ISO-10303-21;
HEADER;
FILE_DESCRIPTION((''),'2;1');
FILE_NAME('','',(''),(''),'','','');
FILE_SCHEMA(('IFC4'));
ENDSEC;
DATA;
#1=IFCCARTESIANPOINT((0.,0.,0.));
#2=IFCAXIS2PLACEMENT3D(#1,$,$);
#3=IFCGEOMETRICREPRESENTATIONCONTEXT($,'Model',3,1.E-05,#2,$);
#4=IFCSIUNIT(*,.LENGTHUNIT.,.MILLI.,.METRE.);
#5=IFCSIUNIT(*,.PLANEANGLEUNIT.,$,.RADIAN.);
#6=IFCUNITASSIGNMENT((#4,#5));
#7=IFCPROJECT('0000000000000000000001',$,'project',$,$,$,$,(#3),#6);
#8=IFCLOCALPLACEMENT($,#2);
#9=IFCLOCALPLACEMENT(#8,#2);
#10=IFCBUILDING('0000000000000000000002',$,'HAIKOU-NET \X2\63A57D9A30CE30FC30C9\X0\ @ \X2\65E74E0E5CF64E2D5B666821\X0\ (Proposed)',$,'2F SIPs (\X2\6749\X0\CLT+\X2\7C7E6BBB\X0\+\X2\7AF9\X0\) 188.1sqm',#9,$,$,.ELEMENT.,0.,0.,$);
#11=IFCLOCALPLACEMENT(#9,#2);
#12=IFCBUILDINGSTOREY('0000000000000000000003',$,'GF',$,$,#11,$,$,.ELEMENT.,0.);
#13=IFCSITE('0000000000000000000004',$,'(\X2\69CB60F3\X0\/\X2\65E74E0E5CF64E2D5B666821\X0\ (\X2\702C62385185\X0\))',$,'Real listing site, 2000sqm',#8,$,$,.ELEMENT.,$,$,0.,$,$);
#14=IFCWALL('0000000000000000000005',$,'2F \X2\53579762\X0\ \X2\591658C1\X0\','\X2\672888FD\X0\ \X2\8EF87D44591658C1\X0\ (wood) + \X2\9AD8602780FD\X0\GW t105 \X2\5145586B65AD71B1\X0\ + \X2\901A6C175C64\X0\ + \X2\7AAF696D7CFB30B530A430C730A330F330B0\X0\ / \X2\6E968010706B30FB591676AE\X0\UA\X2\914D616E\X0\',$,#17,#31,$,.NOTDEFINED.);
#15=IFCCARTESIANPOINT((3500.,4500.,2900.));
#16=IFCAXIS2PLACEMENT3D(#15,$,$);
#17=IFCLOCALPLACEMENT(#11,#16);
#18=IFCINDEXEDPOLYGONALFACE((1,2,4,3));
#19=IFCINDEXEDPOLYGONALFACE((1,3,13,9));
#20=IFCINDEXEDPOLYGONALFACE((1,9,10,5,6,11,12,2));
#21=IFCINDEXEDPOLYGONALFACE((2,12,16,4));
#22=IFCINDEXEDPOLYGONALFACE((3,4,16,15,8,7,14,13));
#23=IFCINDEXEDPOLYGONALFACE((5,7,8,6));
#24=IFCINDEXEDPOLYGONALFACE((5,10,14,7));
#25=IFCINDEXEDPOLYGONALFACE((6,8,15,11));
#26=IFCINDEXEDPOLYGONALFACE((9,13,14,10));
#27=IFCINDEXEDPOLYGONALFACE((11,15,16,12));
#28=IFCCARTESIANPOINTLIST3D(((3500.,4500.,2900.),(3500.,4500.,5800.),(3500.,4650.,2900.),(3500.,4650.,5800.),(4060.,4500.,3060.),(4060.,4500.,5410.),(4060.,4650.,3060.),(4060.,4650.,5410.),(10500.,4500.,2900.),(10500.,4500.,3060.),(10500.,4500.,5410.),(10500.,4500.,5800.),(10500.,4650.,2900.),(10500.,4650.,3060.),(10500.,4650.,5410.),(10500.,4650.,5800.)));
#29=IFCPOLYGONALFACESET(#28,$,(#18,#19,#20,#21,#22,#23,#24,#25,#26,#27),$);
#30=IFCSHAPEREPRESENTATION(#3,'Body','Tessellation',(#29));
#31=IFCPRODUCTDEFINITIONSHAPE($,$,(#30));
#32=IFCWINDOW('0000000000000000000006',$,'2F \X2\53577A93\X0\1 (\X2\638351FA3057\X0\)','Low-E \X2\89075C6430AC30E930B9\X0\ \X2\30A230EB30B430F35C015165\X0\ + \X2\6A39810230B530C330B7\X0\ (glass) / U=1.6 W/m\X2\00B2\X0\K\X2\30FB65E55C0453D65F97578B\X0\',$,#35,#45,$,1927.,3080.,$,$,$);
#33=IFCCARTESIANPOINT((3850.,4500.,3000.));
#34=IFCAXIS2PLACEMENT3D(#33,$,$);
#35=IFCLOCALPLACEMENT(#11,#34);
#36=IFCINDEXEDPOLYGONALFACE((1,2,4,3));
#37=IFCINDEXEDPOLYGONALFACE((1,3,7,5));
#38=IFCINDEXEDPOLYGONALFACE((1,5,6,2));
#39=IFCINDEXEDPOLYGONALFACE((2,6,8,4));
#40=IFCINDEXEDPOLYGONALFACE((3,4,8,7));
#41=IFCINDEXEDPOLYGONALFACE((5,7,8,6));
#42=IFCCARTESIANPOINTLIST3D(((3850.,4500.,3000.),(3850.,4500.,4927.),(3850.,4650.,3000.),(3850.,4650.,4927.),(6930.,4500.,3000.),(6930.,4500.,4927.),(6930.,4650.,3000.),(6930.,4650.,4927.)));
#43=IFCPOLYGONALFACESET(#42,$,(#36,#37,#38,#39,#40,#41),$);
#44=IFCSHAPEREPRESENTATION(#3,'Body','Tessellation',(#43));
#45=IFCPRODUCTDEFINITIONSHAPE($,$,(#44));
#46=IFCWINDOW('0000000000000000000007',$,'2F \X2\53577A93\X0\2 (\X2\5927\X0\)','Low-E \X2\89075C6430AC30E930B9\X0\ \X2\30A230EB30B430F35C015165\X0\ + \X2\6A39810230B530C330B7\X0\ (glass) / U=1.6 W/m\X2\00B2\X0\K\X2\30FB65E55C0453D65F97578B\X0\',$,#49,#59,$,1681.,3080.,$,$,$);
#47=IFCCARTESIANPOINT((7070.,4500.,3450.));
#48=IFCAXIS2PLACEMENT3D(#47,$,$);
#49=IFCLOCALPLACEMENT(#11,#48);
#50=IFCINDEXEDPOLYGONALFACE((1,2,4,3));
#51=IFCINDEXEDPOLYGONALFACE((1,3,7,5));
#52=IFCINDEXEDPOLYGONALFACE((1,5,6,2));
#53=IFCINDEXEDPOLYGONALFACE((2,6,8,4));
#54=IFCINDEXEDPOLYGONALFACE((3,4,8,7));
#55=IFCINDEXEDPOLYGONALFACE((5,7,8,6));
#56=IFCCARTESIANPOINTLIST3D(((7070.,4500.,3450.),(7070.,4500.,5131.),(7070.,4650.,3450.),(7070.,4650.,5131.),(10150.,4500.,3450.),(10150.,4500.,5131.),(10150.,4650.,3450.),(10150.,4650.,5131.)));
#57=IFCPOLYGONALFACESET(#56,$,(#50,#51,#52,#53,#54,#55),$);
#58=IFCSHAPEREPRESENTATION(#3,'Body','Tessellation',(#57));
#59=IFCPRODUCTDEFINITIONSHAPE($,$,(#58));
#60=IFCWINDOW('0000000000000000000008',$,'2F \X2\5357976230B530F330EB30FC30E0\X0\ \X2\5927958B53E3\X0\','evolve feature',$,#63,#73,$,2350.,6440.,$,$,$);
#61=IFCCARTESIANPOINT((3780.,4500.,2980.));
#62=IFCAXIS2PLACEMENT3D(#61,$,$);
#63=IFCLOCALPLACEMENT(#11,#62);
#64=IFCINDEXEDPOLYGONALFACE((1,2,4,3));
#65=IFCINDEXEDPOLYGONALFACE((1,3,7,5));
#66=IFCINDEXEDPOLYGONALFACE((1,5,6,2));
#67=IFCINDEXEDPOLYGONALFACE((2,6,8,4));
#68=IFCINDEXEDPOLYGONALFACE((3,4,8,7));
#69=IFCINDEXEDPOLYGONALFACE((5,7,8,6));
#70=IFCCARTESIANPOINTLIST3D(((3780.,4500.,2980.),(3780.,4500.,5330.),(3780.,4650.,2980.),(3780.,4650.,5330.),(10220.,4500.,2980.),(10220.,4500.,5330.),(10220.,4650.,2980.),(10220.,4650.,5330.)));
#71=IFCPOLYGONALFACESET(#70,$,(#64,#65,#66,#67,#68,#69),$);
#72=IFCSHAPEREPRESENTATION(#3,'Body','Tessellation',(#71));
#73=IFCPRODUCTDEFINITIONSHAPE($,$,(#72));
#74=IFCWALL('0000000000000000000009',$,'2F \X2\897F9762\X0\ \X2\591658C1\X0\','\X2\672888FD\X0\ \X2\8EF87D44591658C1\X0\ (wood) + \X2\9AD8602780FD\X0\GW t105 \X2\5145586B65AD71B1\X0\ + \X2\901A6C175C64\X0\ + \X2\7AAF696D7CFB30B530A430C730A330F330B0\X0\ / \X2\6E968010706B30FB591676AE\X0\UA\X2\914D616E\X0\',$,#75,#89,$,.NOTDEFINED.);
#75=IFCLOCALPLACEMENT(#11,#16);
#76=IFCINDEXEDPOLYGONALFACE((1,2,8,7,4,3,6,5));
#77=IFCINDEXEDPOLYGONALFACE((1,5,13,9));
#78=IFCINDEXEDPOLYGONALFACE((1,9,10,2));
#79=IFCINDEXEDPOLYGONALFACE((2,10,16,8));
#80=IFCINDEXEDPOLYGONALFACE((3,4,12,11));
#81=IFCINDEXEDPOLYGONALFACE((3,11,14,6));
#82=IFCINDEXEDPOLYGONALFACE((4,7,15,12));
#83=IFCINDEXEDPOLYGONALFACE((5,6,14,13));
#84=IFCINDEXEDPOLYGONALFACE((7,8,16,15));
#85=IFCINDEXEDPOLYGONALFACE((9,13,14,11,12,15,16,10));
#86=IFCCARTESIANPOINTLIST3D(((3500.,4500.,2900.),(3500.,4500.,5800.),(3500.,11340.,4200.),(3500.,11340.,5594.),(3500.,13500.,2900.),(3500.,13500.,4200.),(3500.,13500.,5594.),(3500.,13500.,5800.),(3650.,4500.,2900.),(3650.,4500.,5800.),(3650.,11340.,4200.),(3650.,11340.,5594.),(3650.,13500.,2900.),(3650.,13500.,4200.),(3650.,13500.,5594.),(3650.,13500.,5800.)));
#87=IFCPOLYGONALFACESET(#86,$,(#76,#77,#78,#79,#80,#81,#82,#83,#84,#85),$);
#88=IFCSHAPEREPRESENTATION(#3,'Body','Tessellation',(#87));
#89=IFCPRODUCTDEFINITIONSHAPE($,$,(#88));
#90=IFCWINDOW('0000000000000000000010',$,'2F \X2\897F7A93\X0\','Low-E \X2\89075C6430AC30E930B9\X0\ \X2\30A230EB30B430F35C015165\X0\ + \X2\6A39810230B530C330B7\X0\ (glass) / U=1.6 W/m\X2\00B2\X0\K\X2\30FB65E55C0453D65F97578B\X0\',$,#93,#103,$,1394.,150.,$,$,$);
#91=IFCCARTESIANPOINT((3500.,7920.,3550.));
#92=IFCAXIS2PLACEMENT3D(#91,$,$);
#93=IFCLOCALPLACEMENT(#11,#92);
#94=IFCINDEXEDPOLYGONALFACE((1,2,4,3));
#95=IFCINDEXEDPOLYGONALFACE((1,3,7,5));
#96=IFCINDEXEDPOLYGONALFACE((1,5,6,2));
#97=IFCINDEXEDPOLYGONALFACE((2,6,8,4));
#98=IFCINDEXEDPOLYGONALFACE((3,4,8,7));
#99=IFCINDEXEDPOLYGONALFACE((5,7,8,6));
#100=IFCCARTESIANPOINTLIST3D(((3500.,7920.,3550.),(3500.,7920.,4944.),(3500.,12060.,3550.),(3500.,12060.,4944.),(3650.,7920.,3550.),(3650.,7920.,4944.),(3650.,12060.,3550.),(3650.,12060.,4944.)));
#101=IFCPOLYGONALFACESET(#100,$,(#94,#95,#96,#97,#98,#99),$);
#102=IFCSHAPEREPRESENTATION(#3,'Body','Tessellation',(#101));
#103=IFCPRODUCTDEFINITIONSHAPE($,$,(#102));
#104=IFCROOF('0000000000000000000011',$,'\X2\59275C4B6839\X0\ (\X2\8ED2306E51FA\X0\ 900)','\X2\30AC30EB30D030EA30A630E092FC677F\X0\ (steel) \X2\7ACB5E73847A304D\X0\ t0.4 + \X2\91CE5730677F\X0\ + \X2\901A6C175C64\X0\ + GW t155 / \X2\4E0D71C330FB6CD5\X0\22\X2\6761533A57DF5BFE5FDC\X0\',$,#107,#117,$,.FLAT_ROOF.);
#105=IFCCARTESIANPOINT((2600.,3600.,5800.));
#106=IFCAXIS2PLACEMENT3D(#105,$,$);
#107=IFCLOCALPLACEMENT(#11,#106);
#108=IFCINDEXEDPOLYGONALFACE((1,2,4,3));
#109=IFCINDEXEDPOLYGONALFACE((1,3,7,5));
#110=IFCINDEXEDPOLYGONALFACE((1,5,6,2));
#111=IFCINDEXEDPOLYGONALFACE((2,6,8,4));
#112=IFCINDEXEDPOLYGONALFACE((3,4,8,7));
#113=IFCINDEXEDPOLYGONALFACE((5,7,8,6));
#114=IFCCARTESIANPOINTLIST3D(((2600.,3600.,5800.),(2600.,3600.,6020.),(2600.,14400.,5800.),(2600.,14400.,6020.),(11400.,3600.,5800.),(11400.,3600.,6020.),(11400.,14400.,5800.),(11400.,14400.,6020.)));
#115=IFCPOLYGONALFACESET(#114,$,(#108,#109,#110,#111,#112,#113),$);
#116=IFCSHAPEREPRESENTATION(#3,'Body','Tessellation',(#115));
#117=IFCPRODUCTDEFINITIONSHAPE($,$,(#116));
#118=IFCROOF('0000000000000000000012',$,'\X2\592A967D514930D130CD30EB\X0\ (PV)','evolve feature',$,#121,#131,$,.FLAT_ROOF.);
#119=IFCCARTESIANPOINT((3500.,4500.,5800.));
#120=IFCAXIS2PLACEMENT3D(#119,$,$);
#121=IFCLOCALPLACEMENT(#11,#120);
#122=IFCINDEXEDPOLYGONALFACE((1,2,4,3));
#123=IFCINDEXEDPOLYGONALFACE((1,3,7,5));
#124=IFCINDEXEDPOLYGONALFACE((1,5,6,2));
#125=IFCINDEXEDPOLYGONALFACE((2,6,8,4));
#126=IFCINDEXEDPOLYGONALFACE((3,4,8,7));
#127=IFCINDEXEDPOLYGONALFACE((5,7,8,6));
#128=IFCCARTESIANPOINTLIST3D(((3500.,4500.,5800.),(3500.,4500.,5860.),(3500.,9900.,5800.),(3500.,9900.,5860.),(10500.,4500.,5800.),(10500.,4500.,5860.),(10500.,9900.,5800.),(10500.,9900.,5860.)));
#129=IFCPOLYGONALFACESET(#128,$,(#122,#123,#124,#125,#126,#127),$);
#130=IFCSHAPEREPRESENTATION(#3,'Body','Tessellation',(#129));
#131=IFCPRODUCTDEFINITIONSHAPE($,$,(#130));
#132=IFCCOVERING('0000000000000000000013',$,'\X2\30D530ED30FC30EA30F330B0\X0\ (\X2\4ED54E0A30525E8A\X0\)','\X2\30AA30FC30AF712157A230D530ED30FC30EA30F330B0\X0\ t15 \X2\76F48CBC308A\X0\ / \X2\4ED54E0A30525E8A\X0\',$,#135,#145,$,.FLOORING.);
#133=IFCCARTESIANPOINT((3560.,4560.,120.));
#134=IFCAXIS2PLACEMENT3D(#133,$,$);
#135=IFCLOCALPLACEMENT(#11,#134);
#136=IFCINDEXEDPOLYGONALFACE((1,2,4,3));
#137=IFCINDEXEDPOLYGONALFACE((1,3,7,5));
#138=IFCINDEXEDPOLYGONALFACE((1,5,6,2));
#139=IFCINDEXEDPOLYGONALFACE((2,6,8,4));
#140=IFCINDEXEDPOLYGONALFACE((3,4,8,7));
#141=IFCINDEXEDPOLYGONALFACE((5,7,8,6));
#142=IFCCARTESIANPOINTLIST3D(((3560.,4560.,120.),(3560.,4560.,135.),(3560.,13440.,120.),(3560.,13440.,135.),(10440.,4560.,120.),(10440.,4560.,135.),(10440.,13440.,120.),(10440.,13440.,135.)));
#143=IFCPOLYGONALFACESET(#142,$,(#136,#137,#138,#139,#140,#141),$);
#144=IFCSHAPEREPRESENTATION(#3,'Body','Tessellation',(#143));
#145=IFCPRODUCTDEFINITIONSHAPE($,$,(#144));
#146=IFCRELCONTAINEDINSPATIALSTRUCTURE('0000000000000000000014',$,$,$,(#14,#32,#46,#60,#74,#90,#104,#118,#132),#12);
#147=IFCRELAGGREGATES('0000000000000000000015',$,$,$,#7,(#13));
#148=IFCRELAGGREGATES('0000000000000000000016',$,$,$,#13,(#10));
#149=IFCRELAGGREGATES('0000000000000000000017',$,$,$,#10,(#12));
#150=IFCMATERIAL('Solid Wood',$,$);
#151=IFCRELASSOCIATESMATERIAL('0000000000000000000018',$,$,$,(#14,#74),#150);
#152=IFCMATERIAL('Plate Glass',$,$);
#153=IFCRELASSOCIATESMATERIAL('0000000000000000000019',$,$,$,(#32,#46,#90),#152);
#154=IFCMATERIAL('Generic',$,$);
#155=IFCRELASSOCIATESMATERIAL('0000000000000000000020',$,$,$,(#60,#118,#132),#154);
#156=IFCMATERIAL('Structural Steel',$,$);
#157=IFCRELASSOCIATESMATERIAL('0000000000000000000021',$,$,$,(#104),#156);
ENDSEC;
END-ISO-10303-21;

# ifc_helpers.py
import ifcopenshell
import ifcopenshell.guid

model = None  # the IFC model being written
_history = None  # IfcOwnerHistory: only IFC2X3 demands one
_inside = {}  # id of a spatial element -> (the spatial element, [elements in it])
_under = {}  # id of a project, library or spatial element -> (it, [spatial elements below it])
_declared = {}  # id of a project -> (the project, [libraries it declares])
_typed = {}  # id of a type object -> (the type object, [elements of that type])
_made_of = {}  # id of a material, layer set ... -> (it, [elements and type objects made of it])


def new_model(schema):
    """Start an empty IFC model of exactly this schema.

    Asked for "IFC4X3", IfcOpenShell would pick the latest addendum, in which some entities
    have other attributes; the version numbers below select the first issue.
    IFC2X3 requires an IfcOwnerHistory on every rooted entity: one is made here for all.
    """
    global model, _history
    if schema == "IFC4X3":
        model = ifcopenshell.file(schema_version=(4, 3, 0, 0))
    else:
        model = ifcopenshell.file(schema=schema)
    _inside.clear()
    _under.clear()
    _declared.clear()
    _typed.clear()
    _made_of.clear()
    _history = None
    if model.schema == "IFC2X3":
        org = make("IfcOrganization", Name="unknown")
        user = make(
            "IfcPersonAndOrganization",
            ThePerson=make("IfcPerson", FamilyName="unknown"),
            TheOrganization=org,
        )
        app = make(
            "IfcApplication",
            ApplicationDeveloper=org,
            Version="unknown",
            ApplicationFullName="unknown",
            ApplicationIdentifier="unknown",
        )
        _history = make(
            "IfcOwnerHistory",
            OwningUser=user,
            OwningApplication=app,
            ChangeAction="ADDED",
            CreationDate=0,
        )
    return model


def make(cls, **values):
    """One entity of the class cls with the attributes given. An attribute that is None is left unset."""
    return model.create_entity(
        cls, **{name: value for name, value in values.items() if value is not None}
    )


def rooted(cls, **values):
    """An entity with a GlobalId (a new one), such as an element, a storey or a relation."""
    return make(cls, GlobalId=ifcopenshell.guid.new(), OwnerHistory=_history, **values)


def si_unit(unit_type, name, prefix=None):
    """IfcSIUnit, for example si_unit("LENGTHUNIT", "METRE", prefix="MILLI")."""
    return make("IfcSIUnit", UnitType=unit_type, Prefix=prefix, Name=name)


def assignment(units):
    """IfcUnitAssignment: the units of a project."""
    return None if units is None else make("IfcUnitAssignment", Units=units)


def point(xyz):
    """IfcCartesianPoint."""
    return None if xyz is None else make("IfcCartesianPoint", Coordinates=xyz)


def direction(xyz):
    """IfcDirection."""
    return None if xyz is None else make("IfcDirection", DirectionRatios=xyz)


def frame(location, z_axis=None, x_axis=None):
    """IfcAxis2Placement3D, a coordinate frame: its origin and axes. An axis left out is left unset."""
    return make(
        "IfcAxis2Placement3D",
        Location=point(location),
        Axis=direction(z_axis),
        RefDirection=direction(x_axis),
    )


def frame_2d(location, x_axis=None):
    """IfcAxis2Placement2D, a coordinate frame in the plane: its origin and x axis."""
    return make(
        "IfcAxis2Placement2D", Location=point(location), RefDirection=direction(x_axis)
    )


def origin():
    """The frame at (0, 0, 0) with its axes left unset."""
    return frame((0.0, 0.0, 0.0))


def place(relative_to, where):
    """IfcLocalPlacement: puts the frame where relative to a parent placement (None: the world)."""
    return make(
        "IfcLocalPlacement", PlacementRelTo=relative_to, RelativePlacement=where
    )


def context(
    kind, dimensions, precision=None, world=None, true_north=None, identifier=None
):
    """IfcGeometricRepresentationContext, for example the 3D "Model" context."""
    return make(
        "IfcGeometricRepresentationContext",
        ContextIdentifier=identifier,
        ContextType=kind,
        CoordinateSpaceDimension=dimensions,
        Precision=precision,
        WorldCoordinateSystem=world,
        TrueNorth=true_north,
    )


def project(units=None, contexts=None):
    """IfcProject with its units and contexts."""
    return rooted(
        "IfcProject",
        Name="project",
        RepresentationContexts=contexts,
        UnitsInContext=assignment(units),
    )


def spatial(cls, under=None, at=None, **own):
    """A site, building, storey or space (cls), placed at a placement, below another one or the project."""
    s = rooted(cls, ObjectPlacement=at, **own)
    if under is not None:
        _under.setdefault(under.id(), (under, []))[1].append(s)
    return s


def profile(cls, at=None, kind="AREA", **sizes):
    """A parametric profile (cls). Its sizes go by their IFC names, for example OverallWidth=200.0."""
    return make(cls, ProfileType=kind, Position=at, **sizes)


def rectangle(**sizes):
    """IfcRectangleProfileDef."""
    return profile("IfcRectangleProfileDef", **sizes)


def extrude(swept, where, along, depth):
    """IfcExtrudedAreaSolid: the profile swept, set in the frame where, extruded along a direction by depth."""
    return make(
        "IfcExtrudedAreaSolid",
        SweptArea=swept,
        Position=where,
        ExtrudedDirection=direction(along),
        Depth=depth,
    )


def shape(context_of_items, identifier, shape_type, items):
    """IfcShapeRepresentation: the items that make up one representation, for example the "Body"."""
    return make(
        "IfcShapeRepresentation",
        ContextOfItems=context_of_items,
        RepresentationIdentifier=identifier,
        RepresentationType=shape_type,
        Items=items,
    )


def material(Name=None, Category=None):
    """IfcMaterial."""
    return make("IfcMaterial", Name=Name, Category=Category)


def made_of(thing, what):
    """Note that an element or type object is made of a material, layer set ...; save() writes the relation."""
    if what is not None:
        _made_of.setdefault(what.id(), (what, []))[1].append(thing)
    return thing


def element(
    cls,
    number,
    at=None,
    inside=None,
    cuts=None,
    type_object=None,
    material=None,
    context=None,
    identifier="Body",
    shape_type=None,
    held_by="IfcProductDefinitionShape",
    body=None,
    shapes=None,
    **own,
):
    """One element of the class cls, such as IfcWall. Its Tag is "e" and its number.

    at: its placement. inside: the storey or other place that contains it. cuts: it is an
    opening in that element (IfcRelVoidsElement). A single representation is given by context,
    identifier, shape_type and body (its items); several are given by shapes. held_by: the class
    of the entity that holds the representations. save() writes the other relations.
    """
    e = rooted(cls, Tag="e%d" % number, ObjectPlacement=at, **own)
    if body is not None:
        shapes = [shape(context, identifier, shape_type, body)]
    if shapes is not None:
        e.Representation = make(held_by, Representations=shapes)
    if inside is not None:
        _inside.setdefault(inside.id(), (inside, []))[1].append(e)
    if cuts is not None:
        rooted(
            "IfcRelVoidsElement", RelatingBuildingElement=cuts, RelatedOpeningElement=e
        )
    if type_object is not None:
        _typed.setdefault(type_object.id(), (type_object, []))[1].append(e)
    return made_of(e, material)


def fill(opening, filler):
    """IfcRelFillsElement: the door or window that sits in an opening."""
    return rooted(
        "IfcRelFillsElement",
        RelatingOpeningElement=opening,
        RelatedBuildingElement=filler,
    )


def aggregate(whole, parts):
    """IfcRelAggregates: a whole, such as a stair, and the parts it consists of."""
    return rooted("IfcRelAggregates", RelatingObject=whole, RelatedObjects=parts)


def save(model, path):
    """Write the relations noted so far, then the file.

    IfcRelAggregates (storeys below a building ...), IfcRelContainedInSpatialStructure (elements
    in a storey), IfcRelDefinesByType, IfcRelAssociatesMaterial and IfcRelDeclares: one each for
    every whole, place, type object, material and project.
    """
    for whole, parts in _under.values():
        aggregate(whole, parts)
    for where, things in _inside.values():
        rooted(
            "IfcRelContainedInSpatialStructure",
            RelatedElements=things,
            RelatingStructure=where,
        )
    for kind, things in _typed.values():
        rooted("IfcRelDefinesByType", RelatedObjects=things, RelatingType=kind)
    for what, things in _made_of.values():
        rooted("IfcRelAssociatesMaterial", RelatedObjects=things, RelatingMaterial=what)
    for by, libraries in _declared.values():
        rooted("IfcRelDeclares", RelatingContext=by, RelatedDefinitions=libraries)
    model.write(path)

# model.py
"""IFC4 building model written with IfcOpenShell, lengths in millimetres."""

from ifc_helpers import new_model, si_unit, frame, frame_2d, origin, place, context, project, spatial, rectangle, extrude, material, element, fill, save


model = new_model("IFC4")

# Units and contexts
model_context = context("Model", 3, precision=1e-05, world=origin())
ifc_project = project(units=[si_unit("LENGTHUNIT", "METRE", prefix="MILLI"), si_unit("PLANEANGLEUNIT", "RADIAN")], contexts=[model_context])

# Site, building, storey
site_placement = place(None, origin())
site = spatial("IfcSite", under=ifc_project, at=site_placement, Name="(構想/旧与島中学校 (瀬戸内))", ObjectType="Real listing site, 2000sqm", CompositionType="ELEMENT", RefElevation=0.0)
building_placement = place(site_placement, origin())
building = spatial("IfcBuilding", under=site, at=building_placement, Name="HAIKOU-NET 接続ノード @ 旧与島中学校 (Proposed)", ObjectType="2F SIPs (杉CLT+籾殻+竹) 188.1sqm", CompositionType="ELEMENT", ElevationOfRefHeight=0.0, ElevationOfTerrain=0.0)
storey_placement = place(building_placement, origin())
storey = spatial("IfcBuildingStorey", under=building, at=storey_placement, Name="GF", CompositionType="ELEMENT", Elevation=0.0)

# Shared definitions
ifc_material_1 = material(Name="Solid Wood")

# Shared definitions
ifc_material_2 = material(Name="Plate Glass")
ifc_material_3 = material(Name="Generic")

# Wall, openings, windows
wall_1_placement = place(storey_placement, frame((3500.0, 4500.0, 2900.0)))
wall_1 = element("IfcWall", 1, at=wall_1_placement, inside=storey, material=ifc_material_1, Name="2F 南面 外壁", Description="木製 軸組外壁 (wood) + 高性能GW t105 充填断熱 + 通気層 + 窯業系サイディング / 準耐火・外皮UA配慮", PredefinedType="NOTDEFINED", context=model_context, shape_type="SweptSolid", body=[
    extrude(rectangle(XDim=7000.0, YDim=150.0, at=frame_2d((3500.0, 75.0))), frame((3500.0, 4500.0, 2900.0)), (0.0, 0.0, 1.0), 2900.0),
])
opening_1_placement = place(storey_placement, frame((3850.0, 4500.0, 3000.0)))
opening_1 = element("IfcOpeningElement", 2, at=opening_1_placement, cuts=wall_1, PredefinedType="NOTDEFINED", context=model_context, shape_type="SweptSolid", body=[
    extrude(rectangle(XDim=3080.0, YDim=150.0, at=frame_2d((1540.0, 75.0))), frame((3850.0, 4500.0, 3000.0)), (0.0, 0.0, 1.0), 1927.0),
])
opening_2_placement = place(storey_placement, frame((7070.0, 4500.0, 3450.0)))
opening_2 = element("IfcOpeningElement", 3, at=opening_2_placement, cuts=wall_1, PredefinedType="NOTDEFINED", context=model_context, shape_type="SweptSolid", body=[
    extrude(rectangle(XDim=3080.0, YDim=150.0, at=frame_2d((1540.0, 75.0))), frame((7070.0, 4500.0, 3450.0)), (0.0, 0.0, 1.0), 1681.0),
])
opening_3_placement = place(storey_placement, frame((3780.0, 4500.0, 2980.0)))
opening_3 = element("IfcOpeningElement", 4, at=opening_3_placement, cuts=wall_1, PredefinedType="NOTDEFINED", context=model_context, shape_type="SweptSolid", body=[
    extrude(rectangle(XDim=6440.0, YDim=150.0, at=frame_2d((3220.0, 75.0))), frame((3780.0, 4500.0, 2980.0)), (0.0, 0.0, 1.0), 2350.0),
])
window_1_placement = place(storey_placement, frame((3850.0, 4500.0, 3000.0)))
window_1 = element("IfcWindow", 5, at=window_1_placement, inside=storey, material=ifc_material_2, Name="2F 南窓1 (掃出し)", Description="Low-E 複層ガラス アルゴン封入 + 樹脂サッシ (glass) / U=1.6 W/m²K・日射取得型", OverallHeight=1927.0, OverallWidth=3080.0, context=model_context, shape_type="SweptSolid", body=[
    extrude(rectangle(XDim=3080.0, YDim=150.0, at=frame_2d((1540.0, 75.0))), frame((3850.0, 4500.0, 3000.0)), (0.0, 0.0, 1.0), 1927.0),
])
fill(opening_1, window_1)
window_2_placement = place(storey_placement, frame((7070.0, 4500.0, 3450.0)))
window_2 = element("IfcWindow", 6, at=window_2_placement, inside=storey, material=ifc_material_2, Name="2F 南窓2 (大)", Description="Low-E 複層ガラス アルゴン封入 + 樹脂サッシ (glass) / U=1.6 W/m²K・日射取得型", OverallHeight=1681.0, OverallWidth=3080.0, context=model_context, shape_type="SweptSolid", body=[
    extrude(rectangle(XDim=3080.0, YDim=150.0, at=frame_2d((1540.0, 75.0))), frame((7070.0, 4500.0, 3450.0)), (0.0, 0.0, 1.0), 1681.0),
])
fill(opening_2, window_2)
window_3_placement = place(storey_placement, frame((3780.0, 4500.0, 2980.0)))
window_3 = element("IfcWindow", 7, at=window_3_placement, inside=storey, material=ifc_material_3, Name="2F 南面サンルーム 大開口", Description="evolve feature", OverallHeight=2350.0, OverallWidth=6440.0, context=model_context, shape_type="SweptSolid", body=[
    extrude(rectangle(XDim=6440.0, YDim=150.0, at=frame_2d((3220.0, 75.0))), frame((3780.0, 4500.0, 2980.0)), (0.0, 0.0, 1.0), 2350.0),
])
fill(opening_3, window_3)

# Wall, opening, window
wall_2_placement = place(storey_placement, frame((3500.0, 4500.0, 2900.0)))
wall_2 = element("IfcWall", 8, at=wall_2_placement, inside=storey, material=ifc_material_1, Name="2F 西面 外壁", Description="木製 軸組外壁 (wood) + 高性能GW t105 充填断熱 + 通気層 + 窯業系サイディング / 準耐火・外皮UA配慮", PredefinedType="NOTDEFINED", context=model_context, shape_type="SweptSolid", body=[
    extrude(rectangle(XDim=150.0, YDim=9000.0, at=frame_2d((75.0, 4500.0))), frame((3500.0, 4500.0, 2900.0)), (0.0, 0.0, 1.0), 2900.0),
])
opening_4_placement = place(storey_placement, frame((3500.0, 7920.0, 3550.0)))
opening_4 = element("IfcOpeningElement", 9, at=opening_4_placement, cuts=wall_2, PredefinedType="NOTDEFINED", context=model_context, shape_type="SweptSolid", body=[
    extrude(rectangle(XDim=150.0, YDim=4140.0, at=frame_2d((75.0, 2070.0))), frame((3500.0, 7920.0, 3550.0)), (0.0, 0.0, 1.0), 1394.0),
])
window_4_placement = place(storey_placement, frame((3500.0, 7920.0, 3550.0)))
window_4 = element("IfcWindow", 10, at=window_4_placement, inside=storey, material=ifc_material_2, Name="2F 西窓", Description="Low-E 複層ガラス アルゴン封入 + 樹脂サッシ (glass) / U=1.6 W/m²K・日射取得型", OverallHeight=1394.0, OverallWidth=150.0, context=model_context, shape_type="SweptSolid", body=[
    extrude(rectangle(XDim=150.0, YDim=4140.0, at=frame_2d((75.0, 2070.0))), frame((3500.0, 7920.0, 3550.0)), (0.0, 0.0, 1.0), 1394.0),
])
fill(opening_4, window_4)

# Roofs
ifc_material_4 = material(Name="Structural Steel")
roof_1_placement = place(storey_placement, frame((2600.0, 3600.0, 5800.0)))
element("IfcRoof", 11, at=roof_1_placement, inside=storey, material=ifc_material_4, Name="大屋根 (軒の出 900)", Description="ガルバリウム鋼板 (steel) 立平葺き t0.4 + 野地板 + 通気層 + GW t155 / 不燃・法22条区域対応", PredefinedType="FLAT_ROOF", context=model_context, shape_type="SweptSolid", body=[
    extrude(rectangle(XDim=8800.0, YDim=10800.0, at=frame_2d((4400.0, 5400.0))), frame((2600.0, 3600.0, 5800.0)), (0.0, 0.0, 1.0), 220.0),
])
roof_2_placement = place(storey_placement, frame((3500.0, 4500.0, 5800.0)))
element("IfcRoof", 12, at=roof_2_placement, inside=storey, material=ifc_material_3, Name="太陽光パネル (PV)", Description="evolve feature", PredefinedType="FLAT_ROOF", context=model_context, shape_type="SweptSolid", body=[
    extrude(rectangle(XDim=7000.0, YDim=5400.0, at=frame_2d((3500.0, 2700.0))), frame((3500.0, 4500.0, 5800.0)), (0.0, 0.0, 1.0), 60.0),
])

# Covering
covering_placement = place(storey_placement, frame((3560.0, 4560.0, 120.0)))
element("IfcCovering", 13, at=covering_placement, inside=storey, material=ifc_material_3, Name="フローリング (仕上げ床)", Description="オーク無垢フローリング t15 直貼り / 仕上げ床", PredefinedType="FLOORING", context=model_context, shape_type="SweptSolid", body=[
    extrude(rectangle(XDim=6880.0, YDim=8880.0, at=frame_2d((3440.0, 4440.0))), frame((3560.0, 4560.0, 120.0)), (0.0, 0.0, 1.0), 15.0),
])

save(model, "model.ifc")
